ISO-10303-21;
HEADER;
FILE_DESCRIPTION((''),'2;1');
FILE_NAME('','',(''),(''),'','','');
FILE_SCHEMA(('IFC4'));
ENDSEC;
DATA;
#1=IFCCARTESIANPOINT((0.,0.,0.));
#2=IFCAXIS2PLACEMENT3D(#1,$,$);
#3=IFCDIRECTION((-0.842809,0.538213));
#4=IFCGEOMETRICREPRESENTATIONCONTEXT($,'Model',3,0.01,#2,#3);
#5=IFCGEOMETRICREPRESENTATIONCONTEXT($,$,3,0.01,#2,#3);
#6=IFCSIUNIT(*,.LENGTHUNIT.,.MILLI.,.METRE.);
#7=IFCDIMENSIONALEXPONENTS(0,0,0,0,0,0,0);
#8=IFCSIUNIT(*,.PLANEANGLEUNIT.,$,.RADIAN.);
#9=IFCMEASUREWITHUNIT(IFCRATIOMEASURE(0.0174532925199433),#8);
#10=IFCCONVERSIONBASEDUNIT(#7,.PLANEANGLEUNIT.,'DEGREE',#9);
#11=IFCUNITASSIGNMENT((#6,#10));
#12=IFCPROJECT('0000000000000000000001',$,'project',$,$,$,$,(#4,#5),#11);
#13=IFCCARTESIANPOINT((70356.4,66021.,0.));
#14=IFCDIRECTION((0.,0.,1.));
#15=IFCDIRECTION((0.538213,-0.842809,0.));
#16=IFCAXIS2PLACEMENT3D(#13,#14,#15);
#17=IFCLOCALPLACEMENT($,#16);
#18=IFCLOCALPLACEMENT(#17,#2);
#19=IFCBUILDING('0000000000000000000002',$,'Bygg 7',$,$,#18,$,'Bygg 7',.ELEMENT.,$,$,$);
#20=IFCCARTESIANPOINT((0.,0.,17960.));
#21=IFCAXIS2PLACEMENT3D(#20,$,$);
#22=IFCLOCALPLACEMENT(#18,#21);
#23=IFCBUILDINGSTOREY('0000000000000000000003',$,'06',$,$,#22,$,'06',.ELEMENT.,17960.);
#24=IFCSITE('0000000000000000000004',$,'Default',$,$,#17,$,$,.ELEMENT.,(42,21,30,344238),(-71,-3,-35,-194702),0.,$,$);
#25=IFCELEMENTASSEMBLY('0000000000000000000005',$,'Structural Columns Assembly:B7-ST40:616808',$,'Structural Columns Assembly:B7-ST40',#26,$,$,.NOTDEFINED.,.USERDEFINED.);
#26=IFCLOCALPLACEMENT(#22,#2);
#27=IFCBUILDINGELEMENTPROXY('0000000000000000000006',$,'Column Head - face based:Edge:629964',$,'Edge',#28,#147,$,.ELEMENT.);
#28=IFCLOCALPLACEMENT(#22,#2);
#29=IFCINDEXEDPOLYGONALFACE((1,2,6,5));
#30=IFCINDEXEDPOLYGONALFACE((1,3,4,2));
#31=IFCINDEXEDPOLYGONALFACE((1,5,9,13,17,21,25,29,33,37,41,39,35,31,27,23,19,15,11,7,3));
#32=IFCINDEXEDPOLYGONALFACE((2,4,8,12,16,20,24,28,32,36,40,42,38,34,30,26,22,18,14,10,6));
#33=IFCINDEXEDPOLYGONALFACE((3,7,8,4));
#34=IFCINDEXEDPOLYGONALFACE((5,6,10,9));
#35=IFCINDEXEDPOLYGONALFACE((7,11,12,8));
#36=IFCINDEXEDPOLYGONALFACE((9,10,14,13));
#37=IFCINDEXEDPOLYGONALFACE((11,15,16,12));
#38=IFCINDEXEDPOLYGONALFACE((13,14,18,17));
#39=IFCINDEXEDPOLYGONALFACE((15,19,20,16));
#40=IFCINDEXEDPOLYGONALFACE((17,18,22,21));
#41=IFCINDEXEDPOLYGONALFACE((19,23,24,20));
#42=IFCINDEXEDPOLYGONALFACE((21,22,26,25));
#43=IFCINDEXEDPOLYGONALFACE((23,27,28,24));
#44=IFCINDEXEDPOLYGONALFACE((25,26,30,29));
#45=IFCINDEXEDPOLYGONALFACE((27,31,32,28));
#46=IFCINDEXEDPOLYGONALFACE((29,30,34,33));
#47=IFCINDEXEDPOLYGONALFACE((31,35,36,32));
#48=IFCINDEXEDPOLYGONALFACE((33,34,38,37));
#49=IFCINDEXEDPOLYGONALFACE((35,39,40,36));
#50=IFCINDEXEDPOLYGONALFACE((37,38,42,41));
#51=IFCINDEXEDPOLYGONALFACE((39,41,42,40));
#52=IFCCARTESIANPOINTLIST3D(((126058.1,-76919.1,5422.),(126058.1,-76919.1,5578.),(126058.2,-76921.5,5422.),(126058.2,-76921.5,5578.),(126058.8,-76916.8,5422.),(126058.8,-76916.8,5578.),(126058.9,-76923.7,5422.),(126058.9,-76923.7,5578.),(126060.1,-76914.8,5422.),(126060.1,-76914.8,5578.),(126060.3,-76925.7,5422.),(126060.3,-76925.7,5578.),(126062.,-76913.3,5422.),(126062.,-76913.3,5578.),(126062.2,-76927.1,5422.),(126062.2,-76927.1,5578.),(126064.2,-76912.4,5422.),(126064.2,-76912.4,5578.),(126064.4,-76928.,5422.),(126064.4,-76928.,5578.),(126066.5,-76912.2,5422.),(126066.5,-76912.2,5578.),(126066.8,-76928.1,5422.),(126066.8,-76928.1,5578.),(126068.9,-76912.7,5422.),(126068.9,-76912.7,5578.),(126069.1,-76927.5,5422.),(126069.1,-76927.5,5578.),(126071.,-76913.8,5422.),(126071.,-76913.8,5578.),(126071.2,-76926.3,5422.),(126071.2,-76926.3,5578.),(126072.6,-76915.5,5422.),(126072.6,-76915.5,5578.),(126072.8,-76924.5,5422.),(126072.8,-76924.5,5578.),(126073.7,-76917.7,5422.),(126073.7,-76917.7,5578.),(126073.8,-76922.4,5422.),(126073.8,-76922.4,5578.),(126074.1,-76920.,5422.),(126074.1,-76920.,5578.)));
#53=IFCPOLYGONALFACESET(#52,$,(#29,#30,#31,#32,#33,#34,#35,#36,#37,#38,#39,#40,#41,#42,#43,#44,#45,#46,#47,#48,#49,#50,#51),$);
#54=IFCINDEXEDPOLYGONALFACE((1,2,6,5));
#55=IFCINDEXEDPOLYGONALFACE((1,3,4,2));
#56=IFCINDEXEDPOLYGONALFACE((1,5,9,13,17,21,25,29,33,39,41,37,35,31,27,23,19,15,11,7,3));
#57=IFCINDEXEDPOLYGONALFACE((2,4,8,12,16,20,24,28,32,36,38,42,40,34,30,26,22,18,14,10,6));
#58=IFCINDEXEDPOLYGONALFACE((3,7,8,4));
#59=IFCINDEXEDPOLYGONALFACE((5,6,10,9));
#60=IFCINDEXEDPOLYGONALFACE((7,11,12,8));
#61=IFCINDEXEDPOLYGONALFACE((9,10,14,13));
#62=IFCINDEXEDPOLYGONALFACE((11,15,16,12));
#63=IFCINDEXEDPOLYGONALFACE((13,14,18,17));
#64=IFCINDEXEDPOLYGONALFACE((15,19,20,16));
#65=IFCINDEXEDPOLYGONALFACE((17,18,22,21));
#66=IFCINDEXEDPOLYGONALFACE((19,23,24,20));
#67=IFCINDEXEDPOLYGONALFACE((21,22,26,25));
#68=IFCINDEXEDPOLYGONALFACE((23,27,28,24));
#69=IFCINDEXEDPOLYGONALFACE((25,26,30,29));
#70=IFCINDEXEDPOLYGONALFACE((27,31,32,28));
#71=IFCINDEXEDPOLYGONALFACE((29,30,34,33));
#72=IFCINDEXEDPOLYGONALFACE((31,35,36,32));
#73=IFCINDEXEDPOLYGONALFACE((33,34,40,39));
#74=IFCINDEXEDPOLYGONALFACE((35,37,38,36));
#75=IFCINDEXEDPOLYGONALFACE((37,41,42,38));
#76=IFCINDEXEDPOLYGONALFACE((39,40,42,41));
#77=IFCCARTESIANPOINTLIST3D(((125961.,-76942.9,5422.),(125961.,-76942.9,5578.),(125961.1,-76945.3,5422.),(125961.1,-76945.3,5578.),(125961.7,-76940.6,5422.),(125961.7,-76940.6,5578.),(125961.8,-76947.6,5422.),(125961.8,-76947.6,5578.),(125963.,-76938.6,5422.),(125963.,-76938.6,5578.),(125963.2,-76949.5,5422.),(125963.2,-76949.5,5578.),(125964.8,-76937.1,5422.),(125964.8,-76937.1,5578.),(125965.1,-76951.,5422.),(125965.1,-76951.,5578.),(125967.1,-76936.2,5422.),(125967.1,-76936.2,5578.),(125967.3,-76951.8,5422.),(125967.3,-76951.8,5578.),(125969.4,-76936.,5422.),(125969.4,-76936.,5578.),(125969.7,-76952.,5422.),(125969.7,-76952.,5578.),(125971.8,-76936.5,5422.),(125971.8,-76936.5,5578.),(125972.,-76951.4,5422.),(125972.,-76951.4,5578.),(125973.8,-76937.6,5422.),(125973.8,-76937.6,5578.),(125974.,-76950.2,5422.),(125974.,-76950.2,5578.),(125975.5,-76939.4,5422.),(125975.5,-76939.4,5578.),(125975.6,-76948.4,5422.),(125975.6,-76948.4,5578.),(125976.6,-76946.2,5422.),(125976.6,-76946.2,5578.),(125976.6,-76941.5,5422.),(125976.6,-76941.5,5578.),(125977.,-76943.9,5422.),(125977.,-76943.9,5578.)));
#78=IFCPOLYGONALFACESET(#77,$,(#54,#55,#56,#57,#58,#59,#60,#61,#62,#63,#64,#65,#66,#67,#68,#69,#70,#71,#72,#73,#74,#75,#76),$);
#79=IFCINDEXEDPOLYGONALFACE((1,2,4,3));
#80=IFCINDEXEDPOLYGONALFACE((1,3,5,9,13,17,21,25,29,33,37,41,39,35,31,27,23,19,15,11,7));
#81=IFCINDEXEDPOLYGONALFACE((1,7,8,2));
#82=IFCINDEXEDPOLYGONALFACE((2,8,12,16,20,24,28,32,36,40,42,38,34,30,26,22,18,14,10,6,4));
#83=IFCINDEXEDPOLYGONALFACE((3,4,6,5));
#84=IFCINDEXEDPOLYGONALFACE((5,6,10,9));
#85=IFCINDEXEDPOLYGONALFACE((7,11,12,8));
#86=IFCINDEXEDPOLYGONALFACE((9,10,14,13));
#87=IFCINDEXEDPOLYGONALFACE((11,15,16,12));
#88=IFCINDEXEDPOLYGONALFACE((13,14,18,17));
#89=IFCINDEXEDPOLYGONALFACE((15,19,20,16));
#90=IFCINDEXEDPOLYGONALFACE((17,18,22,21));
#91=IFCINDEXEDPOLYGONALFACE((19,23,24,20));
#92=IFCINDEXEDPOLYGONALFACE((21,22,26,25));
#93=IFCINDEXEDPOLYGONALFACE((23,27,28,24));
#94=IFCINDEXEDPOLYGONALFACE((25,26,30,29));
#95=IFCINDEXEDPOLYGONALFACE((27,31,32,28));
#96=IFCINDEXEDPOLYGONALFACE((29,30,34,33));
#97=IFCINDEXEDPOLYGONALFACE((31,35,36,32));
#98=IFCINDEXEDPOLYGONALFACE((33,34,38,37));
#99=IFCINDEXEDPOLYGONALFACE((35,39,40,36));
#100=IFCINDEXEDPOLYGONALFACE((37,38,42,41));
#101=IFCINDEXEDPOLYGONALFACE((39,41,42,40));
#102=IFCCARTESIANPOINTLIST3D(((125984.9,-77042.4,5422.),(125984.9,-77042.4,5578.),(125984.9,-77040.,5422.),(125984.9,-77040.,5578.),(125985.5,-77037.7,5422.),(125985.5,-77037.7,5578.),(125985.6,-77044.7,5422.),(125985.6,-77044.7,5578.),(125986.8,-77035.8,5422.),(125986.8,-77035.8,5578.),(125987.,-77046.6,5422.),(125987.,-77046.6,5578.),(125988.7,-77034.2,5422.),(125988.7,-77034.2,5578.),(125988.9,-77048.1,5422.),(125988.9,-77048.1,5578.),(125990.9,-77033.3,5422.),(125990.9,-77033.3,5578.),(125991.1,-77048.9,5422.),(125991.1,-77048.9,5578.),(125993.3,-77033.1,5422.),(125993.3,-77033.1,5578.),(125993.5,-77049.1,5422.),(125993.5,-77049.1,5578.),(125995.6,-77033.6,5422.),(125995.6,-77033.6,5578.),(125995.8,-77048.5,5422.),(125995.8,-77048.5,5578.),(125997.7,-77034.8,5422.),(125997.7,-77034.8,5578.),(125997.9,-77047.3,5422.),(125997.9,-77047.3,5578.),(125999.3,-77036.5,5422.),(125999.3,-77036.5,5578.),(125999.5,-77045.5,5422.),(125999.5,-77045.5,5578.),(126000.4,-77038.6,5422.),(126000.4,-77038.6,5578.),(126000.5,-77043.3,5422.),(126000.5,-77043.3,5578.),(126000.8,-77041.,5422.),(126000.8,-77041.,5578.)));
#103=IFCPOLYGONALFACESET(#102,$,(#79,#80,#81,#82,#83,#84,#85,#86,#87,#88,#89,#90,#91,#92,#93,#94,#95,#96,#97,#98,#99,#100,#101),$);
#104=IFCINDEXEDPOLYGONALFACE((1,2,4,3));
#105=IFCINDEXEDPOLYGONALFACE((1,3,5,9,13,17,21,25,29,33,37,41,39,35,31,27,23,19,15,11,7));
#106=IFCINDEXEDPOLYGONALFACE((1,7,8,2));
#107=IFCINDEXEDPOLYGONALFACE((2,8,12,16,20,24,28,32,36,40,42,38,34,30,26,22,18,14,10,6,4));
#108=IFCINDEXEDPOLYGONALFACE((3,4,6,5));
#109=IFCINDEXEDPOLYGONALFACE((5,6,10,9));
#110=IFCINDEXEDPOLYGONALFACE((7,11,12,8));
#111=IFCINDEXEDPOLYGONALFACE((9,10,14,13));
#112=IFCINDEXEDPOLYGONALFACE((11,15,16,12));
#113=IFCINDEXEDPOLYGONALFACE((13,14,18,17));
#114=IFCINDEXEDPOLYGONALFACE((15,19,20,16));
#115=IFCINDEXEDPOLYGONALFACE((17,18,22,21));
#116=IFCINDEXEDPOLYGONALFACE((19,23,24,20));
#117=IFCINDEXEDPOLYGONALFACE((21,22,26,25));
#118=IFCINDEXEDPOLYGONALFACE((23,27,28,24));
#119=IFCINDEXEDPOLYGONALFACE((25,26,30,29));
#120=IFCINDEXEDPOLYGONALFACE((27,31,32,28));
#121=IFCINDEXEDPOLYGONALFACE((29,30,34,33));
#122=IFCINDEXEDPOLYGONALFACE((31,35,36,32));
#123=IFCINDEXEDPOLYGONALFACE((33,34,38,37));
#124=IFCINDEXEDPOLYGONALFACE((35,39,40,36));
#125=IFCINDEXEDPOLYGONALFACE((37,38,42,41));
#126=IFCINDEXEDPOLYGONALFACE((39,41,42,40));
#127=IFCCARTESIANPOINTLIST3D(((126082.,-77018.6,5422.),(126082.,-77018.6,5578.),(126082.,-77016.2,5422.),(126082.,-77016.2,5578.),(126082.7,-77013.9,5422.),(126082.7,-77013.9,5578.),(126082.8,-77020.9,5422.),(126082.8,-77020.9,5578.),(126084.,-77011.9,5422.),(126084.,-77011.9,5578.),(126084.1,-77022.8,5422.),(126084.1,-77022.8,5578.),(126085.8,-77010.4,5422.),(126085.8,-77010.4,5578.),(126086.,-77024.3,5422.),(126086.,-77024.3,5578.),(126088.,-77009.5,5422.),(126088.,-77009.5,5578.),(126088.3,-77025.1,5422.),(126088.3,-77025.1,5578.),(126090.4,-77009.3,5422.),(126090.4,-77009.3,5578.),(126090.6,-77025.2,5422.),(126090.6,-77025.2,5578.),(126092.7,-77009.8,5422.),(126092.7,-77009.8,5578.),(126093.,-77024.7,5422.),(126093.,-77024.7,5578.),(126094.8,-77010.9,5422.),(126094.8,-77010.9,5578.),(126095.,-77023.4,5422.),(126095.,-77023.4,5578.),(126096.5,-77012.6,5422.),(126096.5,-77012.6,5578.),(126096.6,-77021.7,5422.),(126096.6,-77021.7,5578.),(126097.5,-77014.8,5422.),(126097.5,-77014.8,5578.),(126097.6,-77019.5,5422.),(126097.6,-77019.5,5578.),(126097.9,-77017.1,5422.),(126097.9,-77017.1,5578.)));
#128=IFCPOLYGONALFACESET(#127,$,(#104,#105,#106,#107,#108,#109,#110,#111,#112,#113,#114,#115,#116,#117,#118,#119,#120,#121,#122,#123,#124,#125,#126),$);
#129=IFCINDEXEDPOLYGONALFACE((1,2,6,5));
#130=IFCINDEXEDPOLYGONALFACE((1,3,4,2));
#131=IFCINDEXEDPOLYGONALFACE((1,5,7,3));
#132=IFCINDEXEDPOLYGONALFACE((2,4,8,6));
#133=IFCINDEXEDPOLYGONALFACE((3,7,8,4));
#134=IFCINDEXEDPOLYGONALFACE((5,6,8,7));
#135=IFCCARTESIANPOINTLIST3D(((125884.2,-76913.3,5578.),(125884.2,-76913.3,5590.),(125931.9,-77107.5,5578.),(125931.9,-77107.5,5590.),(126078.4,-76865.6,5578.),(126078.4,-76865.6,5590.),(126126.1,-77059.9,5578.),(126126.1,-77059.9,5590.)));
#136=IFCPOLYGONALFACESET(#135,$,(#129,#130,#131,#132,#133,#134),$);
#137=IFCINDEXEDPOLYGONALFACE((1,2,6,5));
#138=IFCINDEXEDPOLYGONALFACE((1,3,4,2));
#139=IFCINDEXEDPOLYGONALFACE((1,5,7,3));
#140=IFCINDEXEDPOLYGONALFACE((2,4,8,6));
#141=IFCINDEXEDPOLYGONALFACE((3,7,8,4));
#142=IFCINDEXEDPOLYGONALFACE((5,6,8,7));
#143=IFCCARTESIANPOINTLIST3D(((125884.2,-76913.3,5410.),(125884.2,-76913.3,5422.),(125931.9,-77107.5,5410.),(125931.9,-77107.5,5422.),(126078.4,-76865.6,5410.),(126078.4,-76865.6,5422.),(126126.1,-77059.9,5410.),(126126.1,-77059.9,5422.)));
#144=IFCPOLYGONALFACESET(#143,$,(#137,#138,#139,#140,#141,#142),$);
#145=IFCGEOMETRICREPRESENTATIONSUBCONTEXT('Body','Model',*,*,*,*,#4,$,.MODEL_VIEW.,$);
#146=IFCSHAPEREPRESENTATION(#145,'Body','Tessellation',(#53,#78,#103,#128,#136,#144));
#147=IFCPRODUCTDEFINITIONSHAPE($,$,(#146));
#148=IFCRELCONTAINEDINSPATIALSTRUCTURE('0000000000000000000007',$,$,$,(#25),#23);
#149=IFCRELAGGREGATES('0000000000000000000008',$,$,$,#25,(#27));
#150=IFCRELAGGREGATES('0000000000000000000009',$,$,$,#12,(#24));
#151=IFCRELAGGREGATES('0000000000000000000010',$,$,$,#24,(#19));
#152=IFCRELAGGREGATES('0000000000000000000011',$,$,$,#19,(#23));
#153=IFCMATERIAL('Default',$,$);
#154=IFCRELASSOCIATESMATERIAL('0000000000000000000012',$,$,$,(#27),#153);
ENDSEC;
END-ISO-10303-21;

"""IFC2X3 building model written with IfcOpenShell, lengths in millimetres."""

from ifc_helpers import new_model, entity, si_unit, converted_unit, direction, frame, frame_2d, origin, origin_2d_with_axis, place, context, subcontext, project, spatial, rectangle, circle, extrude, source, transform, mapped, material, element, aggregate, save


model = new_model("IFC2X3")

# Units and contexts
model_context = context("Model", 3, precision=0.01, world=origin(), true_north=direction((-0.842809, 0.538213)))
context_of_model = context(None, 3, precision=0.01, world=origin(), true_north=direction((-0.842809, 0.538213)))
body_context = subcontext(model_context, "Body", "Model", "MODEL_VIEW")
ifc_project = project(units=[si_unit("LENGTHUNIT", "METRE", prefix="MILLI"), converted_unit("PLANEANGLEUNIT", "DEGREE", entity("IfcRatioMeasure", 0.0174532925199433), si_unit("PLANEANGLEUNIT", "RADIAN"), dimensions=[0, 0, 0, 0, 0, 0, 0])], contexts=[model_context, context_of_model])

# Site, building, storey
site_placement = place(None, frame((70356.4, 66021.0, 0.0), z_axis=(0.0, 0.0, 1.0), x_axis=(0.538213, -0.842809, 0.0)))
site = spatial("IfcSite", under=ifc_project, at=site_placement, Name="Default", CompositionType="ELEMENT", RefLatitude=(42, 21, 30, 344238), RefLongitude=(-71, -3, -35, -194702), RefElevation=0.0)
building_placement = place(site_placement, origin())
building = spatial("IfcBuilding", under=site, at=building_placement, Name="Bygg 7", LongName="Bygg 7", CompositionType="ELEMENT")
storey_placement = place(building_placement, frame((0.0, 0.0, 17960.0)))
storey = spatial("IfcBuildingStorey", under=building, at=storey_placement, Name="06", LongName="06", CompositionType="ELEMENT", Elevation=17960.0)

# Element assembly
assembly_1_placement = place(storey_placement, origin())
assembly_1 = element("IfcElementAssembly", 1, at=assembly_1_placement, inside=storey, Name="Structural Columns Assembly:B7-ST40:616808", ObjectType="Structural Columns Assembly:B7-ST40", AssemblyPlace="NOTDEFINED", PredefinedType="USERDEFINED")

# Building element proxy
ifc_material_1 = material(Name="Default")
shared_shape_1 = source(origin(), body_context, "Body", "SweptSolid", [
    extrude(circle(Radius=8.0, at=frame_2d((0.0, 0.0), x_axis=(1.0, 0.0))), frame((50.0, -135.0, 12.0)), (0.0, 0.0, 1.0), 156.0),
    extrude(circle(Radius=8.0, at=frame_2d((0.0, 0.0), x_axis=(1.0, 0.0))), frame((50.0, -35.0, 12.0)), (0.0, 0.0, 1.0), 156.0),
    extrude(circle(Radius=8.0, at=frame_2d((0.0, 0.0), x_axis=(1.0, 0.0))), frame((-50.0, -35.0, 12.0)), (0.0, 0.0, 1.0), 156.0),
    extrude(circle(Radius=8.0, at=frame_2d((0.0, 0.0), x_axis=(1.0, 0.0))), frame((-50.0, -135.0, 12.0)), (0.0, 0.0, 1.0), 156.0),
    extrude(rectangle(XDim=200.0, YDim=200.0, at=origin_2d_with_axis()), frame((0.0, -60.0, 168.0), z_axis=(0.0, 0.0, 1.0), x_axis=(-1.0, 0.0, 0.0)), (0.0, 0.0, 1.0), 12.0),
    extrude(rectangle(XDim=200.0, YDim=200.0, at=origin_2d_with_axis()), frame((0.0, -60.0, 0.0), z_axis=(0.0, 0.0, 1.0), x_axis=(0.0, 1.0, 0.0)), (0.0, 0.0, 1.0), 12.0),
])
proxy_1_placement = place(assembly_1_placement, frame((125946.9, -77000.9, 5410.0), z_axis=(0.0, 0.0, 1.0), x_axis=(-0.238381, 0.971172, 0.0)))
proxy_1 = element("IfcBuildingElementProxy", 2, at=proxy_1_placement, material=ifc_material_1, Name="Column Head - face based:Edge:629964", ObjectType="Edge", CompositionType="ELEMENT", context=body_context, shape_type="MappedRepresentation", body=[
    mapped(shared_shape_1, transform((0.0, 0.0, 0.0), scale=1.0)),
])
aggregate(assembly_1, [proxy_1])

save(model, "model.ifc")
